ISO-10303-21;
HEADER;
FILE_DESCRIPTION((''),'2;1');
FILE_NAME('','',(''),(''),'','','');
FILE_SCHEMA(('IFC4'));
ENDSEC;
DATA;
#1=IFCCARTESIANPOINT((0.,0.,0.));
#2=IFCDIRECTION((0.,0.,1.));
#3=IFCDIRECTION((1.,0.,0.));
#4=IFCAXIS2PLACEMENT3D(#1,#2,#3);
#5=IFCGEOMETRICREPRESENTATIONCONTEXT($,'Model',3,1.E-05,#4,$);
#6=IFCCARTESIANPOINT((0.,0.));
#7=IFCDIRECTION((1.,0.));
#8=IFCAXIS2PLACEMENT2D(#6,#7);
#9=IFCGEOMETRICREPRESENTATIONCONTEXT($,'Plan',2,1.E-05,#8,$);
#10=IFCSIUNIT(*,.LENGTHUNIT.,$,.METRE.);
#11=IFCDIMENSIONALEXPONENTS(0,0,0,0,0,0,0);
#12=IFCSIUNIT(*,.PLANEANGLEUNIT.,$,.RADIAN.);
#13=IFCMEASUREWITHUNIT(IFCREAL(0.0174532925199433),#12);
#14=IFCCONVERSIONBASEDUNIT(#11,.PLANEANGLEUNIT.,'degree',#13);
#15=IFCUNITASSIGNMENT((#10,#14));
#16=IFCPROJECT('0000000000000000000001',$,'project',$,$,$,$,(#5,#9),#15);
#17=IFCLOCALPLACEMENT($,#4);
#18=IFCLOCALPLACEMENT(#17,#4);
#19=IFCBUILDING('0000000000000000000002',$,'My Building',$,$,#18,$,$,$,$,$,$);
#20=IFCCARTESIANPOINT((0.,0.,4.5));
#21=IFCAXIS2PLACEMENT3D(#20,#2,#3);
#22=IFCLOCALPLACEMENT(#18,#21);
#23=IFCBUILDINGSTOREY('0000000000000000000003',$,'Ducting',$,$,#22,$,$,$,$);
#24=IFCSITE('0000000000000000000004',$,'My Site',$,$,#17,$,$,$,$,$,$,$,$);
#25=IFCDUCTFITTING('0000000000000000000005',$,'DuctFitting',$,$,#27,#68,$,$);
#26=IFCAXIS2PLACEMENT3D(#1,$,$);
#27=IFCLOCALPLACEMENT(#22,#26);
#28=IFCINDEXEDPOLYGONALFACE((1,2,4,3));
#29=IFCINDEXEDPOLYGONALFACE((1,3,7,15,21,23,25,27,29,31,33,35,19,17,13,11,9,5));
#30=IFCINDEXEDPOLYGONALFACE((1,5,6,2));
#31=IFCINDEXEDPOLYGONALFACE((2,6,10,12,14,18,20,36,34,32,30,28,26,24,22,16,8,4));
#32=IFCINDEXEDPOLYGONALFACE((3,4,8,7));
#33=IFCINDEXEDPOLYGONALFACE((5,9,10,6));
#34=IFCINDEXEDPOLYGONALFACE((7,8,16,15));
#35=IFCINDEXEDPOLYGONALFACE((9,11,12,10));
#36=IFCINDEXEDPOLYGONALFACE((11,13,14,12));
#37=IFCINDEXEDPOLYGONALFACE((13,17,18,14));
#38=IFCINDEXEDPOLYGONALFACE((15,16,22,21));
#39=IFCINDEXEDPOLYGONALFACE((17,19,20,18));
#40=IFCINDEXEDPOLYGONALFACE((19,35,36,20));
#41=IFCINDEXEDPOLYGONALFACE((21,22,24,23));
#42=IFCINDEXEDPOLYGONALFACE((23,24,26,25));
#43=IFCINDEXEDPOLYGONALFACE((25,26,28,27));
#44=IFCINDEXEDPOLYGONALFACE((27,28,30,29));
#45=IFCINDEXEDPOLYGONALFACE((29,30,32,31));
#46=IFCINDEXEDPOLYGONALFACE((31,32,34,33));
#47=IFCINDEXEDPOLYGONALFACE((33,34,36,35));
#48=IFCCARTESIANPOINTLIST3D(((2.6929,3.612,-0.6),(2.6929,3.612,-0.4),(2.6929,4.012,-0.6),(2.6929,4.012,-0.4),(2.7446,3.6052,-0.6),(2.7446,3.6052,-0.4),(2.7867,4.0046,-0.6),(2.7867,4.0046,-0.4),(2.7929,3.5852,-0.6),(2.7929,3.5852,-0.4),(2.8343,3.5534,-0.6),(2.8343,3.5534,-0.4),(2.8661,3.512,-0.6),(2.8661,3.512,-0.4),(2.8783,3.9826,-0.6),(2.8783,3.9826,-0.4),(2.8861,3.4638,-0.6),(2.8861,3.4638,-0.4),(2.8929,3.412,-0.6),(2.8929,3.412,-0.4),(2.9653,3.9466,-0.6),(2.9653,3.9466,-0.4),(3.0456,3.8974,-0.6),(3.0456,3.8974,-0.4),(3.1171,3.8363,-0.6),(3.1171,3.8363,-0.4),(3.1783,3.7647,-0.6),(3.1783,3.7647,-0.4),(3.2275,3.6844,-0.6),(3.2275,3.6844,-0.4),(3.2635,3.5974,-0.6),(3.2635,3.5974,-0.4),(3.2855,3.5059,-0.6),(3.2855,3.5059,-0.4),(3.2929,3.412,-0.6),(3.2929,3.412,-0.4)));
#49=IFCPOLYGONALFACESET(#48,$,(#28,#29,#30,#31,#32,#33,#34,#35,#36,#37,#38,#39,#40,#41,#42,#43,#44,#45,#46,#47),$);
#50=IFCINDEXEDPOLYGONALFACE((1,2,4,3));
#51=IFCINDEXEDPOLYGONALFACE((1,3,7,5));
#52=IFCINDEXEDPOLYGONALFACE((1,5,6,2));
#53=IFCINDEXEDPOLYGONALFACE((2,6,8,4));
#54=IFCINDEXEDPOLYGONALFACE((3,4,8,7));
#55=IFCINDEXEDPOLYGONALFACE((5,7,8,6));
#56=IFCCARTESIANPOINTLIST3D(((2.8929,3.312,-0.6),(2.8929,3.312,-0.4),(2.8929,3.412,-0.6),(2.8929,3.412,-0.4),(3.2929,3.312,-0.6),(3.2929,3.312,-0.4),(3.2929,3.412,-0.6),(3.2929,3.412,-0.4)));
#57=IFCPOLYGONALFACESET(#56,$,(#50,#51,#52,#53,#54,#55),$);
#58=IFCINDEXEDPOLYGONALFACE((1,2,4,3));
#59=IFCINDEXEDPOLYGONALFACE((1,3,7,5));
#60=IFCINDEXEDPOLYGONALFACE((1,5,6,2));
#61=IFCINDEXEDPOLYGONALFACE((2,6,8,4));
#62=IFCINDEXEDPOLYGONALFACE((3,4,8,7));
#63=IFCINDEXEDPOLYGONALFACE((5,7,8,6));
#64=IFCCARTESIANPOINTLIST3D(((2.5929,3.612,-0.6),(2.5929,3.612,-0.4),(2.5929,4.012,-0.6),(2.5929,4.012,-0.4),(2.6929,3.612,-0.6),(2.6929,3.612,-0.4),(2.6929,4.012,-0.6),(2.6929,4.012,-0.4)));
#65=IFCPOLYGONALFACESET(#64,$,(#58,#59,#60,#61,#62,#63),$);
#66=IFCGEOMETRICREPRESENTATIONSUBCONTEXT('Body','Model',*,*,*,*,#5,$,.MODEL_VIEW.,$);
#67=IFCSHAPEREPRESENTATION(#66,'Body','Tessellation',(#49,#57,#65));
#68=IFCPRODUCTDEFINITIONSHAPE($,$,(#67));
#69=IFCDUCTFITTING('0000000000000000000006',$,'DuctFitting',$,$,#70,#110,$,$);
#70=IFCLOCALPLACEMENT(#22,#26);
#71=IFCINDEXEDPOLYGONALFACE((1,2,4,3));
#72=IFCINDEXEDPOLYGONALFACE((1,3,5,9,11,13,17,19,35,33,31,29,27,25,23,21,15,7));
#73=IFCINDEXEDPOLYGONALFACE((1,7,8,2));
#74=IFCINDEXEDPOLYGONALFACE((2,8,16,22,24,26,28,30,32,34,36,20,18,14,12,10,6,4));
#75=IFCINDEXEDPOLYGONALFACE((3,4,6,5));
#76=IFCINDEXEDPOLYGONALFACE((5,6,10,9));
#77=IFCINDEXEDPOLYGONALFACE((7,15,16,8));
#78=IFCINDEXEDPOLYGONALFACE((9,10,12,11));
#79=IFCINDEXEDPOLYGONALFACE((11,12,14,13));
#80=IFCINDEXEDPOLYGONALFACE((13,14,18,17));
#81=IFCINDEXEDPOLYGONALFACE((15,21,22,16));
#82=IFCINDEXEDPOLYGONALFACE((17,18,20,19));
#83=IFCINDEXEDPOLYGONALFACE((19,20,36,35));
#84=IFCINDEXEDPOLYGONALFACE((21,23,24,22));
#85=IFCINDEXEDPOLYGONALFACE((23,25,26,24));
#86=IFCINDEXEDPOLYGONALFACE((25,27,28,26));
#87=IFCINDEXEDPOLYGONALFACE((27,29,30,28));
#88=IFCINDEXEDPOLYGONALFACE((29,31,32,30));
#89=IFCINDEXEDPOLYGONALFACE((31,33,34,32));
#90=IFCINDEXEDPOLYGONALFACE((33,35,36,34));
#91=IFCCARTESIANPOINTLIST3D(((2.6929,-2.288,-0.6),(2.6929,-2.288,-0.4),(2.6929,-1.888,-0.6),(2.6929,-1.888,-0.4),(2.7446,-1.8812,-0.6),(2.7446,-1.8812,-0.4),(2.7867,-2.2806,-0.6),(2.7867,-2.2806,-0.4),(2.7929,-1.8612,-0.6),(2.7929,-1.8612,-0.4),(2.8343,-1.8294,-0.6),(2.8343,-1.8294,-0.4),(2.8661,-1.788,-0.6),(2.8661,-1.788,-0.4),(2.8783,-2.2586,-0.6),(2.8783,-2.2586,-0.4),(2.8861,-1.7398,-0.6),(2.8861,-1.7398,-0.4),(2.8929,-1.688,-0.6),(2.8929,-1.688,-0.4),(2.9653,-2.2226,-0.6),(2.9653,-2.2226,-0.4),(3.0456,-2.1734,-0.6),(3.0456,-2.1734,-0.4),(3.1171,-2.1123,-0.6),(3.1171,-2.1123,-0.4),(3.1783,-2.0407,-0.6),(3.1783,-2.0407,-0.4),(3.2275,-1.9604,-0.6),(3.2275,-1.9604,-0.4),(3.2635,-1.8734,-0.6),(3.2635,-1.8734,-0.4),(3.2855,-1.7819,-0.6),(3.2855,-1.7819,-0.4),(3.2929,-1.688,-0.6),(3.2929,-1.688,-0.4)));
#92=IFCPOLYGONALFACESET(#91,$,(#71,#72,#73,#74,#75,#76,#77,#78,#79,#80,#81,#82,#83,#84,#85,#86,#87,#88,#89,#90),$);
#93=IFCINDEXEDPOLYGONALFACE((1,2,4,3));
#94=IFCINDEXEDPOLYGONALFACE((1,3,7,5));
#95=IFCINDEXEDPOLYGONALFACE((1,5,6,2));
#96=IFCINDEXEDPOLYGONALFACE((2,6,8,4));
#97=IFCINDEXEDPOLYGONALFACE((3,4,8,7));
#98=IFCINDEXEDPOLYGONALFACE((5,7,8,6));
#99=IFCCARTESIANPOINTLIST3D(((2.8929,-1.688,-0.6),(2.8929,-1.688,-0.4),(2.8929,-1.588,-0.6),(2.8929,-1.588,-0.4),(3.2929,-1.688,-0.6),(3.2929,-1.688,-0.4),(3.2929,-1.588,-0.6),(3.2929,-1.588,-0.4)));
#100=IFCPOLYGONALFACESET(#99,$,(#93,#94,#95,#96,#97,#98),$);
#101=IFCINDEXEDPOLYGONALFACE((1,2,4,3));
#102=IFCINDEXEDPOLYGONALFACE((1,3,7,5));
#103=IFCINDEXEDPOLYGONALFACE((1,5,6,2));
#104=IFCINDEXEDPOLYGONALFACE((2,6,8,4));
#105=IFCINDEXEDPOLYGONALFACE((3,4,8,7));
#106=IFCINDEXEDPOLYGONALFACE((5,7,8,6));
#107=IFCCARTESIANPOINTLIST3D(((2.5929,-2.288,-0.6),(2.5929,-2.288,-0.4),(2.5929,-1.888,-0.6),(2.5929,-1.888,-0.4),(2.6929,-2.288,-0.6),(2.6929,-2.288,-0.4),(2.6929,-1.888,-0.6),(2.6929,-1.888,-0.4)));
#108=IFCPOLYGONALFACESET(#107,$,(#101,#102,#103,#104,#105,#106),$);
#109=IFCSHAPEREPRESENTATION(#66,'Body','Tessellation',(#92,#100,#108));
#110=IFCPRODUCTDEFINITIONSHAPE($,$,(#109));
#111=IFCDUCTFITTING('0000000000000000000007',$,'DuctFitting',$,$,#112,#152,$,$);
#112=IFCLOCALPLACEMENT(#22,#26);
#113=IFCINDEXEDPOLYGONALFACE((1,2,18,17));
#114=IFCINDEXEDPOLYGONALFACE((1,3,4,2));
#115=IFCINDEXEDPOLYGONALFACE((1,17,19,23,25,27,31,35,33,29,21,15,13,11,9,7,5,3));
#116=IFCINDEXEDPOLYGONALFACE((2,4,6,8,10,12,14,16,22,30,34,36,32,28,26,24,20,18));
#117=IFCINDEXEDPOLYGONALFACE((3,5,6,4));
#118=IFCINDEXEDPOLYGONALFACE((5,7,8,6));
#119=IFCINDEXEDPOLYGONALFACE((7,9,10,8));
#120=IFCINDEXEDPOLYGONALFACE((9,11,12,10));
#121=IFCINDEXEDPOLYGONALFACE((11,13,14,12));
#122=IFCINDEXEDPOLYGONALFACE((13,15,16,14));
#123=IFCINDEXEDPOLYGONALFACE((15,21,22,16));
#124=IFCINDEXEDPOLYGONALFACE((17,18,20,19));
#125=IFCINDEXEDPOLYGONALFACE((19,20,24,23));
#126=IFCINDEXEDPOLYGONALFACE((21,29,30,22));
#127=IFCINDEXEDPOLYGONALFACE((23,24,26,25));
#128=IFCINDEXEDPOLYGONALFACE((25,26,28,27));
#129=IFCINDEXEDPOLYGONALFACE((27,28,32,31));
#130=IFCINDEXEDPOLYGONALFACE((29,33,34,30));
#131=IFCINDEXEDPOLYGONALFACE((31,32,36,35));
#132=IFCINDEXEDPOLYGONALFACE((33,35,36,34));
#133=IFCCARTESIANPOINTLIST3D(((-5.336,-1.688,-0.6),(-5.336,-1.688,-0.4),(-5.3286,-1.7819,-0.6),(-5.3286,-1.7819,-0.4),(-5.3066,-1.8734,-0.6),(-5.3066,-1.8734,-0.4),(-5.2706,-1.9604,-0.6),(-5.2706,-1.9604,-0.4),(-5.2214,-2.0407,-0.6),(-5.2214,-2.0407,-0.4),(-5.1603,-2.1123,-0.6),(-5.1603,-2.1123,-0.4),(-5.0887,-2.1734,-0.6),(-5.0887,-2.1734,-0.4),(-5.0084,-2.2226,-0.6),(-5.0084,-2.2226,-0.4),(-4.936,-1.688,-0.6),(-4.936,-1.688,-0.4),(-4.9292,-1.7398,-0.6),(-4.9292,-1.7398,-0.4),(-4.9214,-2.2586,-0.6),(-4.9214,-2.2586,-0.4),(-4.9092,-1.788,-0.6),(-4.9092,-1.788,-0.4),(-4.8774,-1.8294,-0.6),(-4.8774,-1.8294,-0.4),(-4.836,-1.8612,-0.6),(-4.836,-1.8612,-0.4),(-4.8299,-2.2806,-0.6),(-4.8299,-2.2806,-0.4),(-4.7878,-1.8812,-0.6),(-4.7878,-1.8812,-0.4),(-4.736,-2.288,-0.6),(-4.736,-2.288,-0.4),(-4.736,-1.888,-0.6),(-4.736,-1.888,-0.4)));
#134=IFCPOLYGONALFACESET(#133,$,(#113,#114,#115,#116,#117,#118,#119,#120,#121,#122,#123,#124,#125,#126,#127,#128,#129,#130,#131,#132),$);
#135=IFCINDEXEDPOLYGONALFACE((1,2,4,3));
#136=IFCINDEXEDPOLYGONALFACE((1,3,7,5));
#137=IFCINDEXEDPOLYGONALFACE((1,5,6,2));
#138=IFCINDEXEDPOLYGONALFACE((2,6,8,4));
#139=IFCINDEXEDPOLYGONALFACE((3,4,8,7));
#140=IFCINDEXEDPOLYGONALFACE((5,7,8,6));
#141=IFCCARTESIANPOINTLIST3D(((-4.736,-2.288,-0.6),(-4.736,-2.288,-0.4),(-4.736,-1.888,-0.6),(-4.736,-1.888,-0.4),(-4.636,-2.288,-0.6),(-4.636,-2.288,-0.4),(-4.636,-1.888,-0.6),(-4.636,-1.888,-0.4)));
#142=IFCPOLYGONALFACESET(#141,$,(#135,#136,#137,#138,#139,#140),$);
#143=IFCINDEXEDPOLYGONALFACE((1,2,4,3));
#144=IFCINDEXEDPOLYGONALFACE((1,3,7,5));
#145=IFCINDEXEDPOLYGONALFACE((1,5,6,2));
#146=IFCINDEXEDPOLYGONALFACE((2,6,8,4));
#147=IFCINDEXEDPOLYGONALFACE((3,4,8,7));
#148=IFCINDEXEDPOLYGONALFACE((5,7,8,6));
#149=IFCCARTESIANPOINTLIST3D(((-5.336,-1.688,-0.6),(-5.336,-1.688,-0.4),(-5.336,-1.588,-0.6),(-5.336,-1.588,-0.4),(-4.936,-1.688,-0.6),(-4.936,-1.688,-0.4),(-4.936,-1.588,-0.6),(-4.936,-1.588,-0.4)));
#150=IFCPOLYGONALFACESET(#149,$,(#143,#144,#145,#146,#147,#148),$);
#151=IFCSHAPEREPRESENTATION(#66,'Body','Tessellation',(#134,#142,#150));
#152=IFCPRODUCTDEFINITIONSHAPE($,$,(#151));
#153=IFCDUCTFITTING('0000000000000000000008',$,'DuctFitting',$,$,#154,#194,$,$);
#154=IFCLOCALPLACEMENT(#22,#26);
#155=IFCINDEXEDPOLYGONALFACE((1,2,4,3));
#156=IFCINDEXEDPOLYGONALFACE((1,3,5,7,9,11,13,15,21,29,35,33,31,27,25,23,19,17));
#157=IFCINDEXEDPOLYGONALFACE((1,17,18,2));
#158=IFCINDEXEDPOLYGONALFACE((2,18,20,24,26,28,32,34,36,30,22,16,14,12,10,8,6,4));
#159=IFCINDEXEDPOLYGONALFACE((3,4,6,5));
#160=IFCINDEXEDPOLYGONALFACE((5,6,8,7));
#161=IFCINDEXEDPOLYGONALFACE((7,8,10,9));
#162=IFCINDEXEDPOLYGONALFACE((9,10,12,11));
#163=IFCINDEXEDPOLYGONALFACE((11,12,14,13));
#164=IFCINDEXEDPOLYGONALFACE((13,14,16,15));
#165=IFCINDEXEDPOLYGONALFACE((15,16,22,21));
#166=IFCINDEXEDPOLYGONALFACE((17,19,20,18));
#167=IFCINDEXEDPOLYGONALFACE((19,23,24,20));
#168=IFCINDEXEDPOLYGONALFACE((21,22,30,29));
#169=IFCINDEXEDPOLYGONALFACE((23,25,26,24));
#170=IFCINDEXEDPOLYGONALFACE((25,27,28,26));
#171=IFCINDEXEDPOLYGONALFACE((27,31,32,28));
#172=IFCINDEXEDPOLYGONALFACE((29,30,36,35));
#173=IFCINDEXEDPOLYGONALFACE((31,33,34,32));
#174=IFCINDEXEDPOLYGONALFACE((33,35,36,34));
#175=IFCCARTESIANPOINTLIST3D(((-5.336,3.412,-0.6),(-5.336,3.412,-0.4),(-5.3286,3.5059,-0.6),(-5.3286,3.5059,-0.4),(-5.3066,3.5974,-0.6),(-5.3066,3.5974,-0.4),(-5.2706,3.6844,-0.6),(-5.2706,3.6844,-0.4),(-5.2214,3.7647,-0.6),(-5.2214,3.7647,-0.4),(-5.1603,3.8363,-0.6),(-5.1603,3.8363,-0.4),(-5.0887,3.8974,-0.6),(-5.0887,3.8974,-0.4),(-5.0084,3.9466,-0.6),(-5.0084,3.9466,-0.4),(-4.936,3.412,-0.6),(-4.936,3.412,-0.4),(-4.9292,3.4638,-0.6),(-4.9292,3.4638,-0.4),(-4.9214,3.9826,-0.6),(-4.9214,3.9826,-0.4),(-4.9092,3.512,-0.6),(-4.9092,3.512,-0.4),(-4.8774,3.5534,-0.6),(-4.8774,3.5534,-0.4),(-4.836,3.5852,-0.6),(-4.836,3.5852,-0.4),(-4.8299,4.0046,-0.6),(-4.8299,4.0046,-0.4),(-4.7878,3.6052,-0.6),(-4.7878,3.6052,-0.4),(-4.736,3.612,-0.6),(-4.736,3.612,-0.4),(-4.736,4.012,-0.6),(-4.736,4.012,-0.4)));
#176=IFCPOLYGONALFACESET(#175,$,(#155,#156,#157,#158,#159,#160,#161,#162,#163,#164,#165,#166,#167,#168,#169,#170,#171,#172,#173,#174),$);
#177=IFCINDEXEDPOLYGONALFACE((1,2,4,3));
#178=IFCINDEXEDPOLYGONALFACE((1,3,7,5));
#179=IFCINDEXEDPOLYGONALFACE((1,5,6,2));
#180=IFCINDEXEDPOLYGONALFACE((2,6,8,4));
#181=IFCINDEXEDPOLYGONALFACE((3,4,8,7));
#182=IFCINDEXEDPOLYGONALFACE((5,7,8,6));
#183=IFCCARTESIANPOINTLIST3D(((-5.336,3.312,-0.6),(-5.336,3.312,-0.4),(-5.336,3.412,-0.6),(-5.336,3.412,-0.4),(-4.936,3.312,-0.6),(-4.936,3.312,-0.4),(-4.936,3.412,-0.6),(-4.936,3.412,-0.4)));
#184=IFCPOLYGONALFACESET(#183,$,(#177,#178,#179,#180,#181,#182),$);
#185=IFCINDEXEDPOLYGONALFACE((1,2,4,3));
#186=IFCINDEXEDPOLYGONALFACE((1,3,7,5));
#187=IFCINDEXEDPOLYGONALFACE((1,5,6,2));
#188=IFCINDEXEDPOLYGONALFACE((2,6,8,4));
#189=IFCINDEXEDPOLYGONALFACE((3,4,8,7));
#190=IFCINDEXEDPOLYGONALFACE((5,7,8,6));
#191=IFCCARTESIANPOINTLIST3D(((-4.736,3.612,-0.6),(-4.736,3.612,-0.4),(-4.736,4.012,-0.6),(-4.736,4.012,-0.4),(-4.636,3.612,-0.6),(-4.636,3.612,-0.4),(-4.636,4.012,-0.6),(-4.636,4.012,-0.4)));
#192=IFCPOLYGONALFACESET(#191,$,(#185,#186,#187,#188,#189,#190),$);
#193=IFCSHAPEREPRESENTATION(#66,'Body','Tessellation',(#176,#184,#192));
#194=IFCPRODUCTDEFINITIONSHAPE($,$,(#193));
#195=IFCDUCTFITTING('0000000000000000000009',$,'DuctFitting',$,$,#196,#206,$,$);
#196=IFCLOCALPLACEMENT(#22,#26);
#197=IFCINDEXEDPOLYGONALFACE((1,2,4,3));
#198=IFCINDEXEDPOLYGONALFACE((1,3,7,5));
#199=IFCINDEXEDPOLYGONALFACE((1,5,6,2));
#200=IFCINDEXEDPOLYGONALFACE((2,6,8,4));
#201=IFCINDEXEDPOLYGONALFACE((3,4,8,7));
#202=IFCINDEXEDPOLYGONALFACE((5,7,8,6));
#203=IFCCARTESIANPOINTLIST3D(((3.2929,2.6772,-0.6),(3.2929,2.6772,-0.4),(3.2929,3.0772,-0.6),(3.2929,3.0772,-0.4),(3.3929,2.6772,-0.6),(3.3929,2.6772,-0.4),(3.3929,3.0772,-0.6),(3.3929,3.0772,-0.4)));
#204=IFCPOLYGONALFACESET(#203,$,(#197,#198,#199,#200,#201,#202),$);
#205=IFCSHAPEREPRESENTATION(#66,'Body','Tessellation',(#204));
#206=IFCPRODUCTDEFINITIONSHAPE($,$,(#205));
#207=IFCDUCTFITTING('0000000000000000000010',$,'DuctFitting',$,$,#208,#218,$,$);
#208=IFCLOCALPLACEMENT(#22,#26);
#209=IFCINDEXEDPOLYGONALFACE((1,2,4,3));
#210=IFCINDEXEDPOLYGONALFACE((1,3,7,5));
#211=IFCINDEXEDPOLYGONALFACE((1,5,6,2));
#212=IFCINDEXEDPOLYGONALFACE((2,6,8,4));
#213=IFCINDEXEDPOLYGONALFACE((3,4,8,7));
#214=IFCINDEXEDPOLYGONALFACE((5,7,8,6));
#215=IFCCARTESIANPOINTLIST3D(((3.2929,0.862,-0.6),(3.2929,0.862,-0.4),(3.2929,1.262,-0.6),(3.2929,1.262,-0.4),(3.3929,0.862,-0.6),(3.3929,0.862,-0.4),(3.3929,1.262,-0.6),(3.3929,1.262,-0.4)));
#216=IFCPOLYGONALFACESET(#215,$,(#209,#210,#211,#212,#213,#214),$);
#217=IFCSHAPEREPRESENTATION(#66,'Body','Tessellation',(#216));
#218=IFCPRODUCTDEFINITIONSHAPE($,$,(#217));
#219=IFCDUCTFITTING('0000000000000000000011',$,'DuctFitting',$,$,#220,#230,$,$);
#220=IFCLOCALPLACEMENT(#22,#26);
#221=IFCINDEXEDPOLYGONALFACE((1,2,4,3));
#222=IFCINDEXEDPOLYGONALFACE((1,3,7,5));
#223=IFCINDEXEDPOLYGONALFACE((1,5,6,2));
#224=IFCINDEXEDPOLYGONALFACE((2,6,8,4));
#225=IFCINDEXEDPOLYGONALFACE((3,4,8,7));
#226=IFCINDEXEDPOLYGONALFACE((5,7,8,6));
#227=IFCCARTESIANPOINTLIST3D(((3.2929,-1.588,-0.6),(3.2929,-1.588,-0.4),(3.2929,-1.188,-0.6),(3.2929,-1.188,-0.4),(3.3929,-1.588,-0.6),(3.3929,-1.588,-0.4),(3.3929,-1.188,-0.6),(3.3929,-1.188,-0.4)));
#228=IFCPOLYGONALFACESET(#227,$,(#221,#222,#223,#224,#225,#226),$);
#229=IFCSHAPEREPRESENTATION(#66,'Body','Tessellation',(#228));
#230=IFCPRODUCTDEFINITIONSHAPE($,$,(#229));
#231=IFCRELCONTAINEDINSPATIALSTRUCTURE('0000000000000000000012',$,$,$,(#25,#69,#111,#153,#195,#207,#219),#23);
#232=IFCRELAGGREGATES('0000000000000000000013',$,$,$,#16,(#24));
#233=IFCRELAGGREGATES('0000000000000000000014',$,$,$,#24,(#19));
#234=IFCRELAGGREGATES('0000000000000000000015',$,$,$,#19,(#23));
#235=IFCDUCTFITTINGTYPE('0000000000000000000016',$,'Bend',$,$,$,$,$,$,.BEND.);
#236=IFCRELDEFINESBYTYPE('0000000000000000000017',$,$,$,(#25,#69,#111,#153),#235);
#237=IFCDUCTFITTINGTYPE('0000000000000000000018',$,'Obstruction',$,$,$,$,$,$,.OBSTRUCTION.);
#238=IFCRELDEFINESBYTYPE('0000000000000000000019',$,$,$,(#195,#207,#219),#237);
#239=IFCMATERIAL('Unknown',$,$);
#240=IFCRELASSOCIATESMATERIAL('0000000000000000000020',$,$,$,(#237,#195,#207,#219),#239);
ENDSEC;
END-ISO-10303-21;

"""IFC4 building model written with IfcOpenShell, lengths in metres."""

from ifc_helpers import new_model, entity, si_unit, converted_unit, frame, origin_with_axes, origin_2d_with_axis, place, context, subcontext, project, spatial, line, arc, indexed_curve, rectangle, outline, extrude, source, transform, mapped, material, material_profile, profile_set, profile_usage, type_object, type_shapes, element, save


model = new_model("IFC4")

# Units and contexts
model_context = context("Model", 3, precision=1e-05, world=origin_with_axes())
plan_context = context("Plan", 2, precision=1e-05, world=origin_2d_with_axis())
body_context = subcontext(model_context, "Body", "Model", "MODEL_VIEW")
ifc_project = project(units=[si_unit("LENGTHUNIT", "METRE"), converted_unit("PLANEANGLEUNIT", "degree", entity("IfcReal", 0.0174532925199433), si_unit("PLANEANGLEUNIT", "RADIAN"), dimensions=[0, 0, 0, 0, 0, 0, 0])], contexts=[model_context, plan_context])

# Site, building, storey
site_placement = place(None, origin_with_axes())
site = spatial("IfcSite", under=ifc_project, at=site_placement, Name="My Site")
building_placement = place(site_placement, origin_with_axes())
building = spatial("IfcBuilding", under=site, at=building_placement, Name="My Building")
storey_placement = place(building_placement, frame((0.0, 0.0, 4.5), z_axis=(0.0, 0.0, 1.0), x_axis=(1.0, 0.0, 0.0)))
storey = spatial("IfcBuildingStorey", under=building, at=storey_placement, Name="Ducting")

# Shared definitions
ifc_material = material(Name="Unknown")

# Duct fittings
duct_fitting_type_1 = type_object("IfcDuctFittingType", Name="Bend", PredefinedType="BEND")
shared_shape = source(origin_with_axes(), body_context, "Body", "SweptSolid", [
    extrude(outline(indexed_curve([(0.2, 0.0), (0.2586, 0.1414), (0.4, 0.2), (0.4, 0.6), (-0.0243, 0.4243), (-0.2, 0.0)], segments=[arc(1, 2, 3), line(3, 4), arc(4, 5, 6), line(6, 1)])), frame((0.0, -0.1, 0.1), z_axis=(0.0, -1.0, 0.0), x_axis=(1.0, 0.0, 0.0)), (0.0, 0.0, -1.0), 0.2),
    extrude(rectangle(XDim=0.4, YDim=0.2), origin_with_axes(), (0.0, 0.0, 1.0), 0.1),
    extrude(rectangle(XDim=0.4, YDim=0.2), frame((0.4, 0.0, 0.5), z_axis=(1.0, 0.0, 0.0), x_axis=(0.0, 0.0, 1.0)), (0.0, 0.0, 1.0), 0.1),
])
type_shapes(duct_fitting_type_1, [shared_shape])
for number, where, z_axis, x_axis, name in (
    (1, (3.0929, 3.312, -0.5), (0.0, 1.0, 0.0), (-1.0, 0.0, 0.0), "DuctFitting"),
    (2, (3.0929, -1.588, -0.5), (0.0, -1.0, 0.0), (-1.0, 0.0, 0.0), "DuctFitting"),
    (3, (-4.636, -2.088, -0.5), (-1.0, 0.0, -0.000001), (0.0, 1.0, 0.0), "DuctFitting"),
    (4, (-5.136, 3.312, -0.5), (0.0, 1.0, 0.0), (1.0, 0.0, 0.0), "DuctFitting"),
):
    element("IfcDuctFitting", number, at=place(storey_placement, frame(where, z_axis=z_axis, x_axis=x_axis)), inside=storey, type_object=duct_fitting_type_1, Name=name, context=body_context, shape_type="MappedRepresentation", body=[
        mapped(shared_shape, transform((0.0, 0.0, 0.0), x_axis=(1.0, 0.0, 0.0), y_axis=(0.0, 1.0, 0.0), z_axis=(0.0, 0.0, 1.0), scale=1.0)),
    ])
ifc_material_profile_1 = material_profile(ifc_material, rectangle(XDim=0.4, YDim=0.2))
ifc_profile_set_1 = profile_set([ifc_material_profile_1])
ifc_profile_usage_1 = profile_usage(ifc_profile_set_1, cardinal=5)
duct_fitting_type_2 = type_object("IfcDuctFittingType", Name="Obstruction", PredefinedType="OBSTRUCTION", material=ifc_profile_set_1)
duct_fitting_1_placement = place(storey_placement, frame((3.2929, 2.8772, -0.5), z_axis=(1.0, 0.0, 0.0), x_axis=(0.0, 1.0, 0.0)))
element("IfcDuctFitting", 5, at=duct_fitting_1_placement, inside=storey, type_object=duct_fitting_type_2, material=ifc_profile_usage_1, Name="DuctFitting", context=body_context, shape_type="SweptSolid", body=[
    extrude(rectangle(XDim=0.4, YDim=0.2), origin_with_axes(), (0.0, 0.0, 1.0), 0.1),
])
ifc_profile_usage_2 = profile_usage(ifc_profile_set_1, cardinal=5)
duct_fitting_2_placement = place(storey_placement, frame((3.2929, 1.062, -0.5), z_axis=(1.0, 0.0, 0.0), x_axis=(0.0, 1.0, 0.0)))
element("IfcDuctFitting", 6, at=duct_fitting_2_placement, inside=storey, type_object=duct_fitting_type_2, material=ifc_profile_usage_2, Name="DuctFitting", context=body_context, shape_type="SweptSolid", body=[
    extrude(rectangle(XDim=0.4, YDim=0.2), origin_with_axes(), (0.0, 0.0, 1.0), 0.1),
])
ifc_profile_usage_3 = profile_usage(ifc_profile_set_1, cardinal=5)
duct_fitting_3_placement = place(storey_placement, frame((3.2929, -1.388, -0.5), z_axis=(1.0, 0.0, 0.0), x_axis=(0.0, 1.0, 0.0)))
element("IfcDuctFitting", 7, at=duct_fitting_3_placement, inside=storey, type_object=duct_fitting_type_2, material=ifc_profile_usage_3, Name="DuctFitting", context=body_context, shape_type="SweptSolid", body=[
    extrude(rectangle(XDim=0.4, YDim=0.2), origin_with_axes(), (0.0, 0.0, 1.0), 0.1),
])

save(model, "model.ifc")
